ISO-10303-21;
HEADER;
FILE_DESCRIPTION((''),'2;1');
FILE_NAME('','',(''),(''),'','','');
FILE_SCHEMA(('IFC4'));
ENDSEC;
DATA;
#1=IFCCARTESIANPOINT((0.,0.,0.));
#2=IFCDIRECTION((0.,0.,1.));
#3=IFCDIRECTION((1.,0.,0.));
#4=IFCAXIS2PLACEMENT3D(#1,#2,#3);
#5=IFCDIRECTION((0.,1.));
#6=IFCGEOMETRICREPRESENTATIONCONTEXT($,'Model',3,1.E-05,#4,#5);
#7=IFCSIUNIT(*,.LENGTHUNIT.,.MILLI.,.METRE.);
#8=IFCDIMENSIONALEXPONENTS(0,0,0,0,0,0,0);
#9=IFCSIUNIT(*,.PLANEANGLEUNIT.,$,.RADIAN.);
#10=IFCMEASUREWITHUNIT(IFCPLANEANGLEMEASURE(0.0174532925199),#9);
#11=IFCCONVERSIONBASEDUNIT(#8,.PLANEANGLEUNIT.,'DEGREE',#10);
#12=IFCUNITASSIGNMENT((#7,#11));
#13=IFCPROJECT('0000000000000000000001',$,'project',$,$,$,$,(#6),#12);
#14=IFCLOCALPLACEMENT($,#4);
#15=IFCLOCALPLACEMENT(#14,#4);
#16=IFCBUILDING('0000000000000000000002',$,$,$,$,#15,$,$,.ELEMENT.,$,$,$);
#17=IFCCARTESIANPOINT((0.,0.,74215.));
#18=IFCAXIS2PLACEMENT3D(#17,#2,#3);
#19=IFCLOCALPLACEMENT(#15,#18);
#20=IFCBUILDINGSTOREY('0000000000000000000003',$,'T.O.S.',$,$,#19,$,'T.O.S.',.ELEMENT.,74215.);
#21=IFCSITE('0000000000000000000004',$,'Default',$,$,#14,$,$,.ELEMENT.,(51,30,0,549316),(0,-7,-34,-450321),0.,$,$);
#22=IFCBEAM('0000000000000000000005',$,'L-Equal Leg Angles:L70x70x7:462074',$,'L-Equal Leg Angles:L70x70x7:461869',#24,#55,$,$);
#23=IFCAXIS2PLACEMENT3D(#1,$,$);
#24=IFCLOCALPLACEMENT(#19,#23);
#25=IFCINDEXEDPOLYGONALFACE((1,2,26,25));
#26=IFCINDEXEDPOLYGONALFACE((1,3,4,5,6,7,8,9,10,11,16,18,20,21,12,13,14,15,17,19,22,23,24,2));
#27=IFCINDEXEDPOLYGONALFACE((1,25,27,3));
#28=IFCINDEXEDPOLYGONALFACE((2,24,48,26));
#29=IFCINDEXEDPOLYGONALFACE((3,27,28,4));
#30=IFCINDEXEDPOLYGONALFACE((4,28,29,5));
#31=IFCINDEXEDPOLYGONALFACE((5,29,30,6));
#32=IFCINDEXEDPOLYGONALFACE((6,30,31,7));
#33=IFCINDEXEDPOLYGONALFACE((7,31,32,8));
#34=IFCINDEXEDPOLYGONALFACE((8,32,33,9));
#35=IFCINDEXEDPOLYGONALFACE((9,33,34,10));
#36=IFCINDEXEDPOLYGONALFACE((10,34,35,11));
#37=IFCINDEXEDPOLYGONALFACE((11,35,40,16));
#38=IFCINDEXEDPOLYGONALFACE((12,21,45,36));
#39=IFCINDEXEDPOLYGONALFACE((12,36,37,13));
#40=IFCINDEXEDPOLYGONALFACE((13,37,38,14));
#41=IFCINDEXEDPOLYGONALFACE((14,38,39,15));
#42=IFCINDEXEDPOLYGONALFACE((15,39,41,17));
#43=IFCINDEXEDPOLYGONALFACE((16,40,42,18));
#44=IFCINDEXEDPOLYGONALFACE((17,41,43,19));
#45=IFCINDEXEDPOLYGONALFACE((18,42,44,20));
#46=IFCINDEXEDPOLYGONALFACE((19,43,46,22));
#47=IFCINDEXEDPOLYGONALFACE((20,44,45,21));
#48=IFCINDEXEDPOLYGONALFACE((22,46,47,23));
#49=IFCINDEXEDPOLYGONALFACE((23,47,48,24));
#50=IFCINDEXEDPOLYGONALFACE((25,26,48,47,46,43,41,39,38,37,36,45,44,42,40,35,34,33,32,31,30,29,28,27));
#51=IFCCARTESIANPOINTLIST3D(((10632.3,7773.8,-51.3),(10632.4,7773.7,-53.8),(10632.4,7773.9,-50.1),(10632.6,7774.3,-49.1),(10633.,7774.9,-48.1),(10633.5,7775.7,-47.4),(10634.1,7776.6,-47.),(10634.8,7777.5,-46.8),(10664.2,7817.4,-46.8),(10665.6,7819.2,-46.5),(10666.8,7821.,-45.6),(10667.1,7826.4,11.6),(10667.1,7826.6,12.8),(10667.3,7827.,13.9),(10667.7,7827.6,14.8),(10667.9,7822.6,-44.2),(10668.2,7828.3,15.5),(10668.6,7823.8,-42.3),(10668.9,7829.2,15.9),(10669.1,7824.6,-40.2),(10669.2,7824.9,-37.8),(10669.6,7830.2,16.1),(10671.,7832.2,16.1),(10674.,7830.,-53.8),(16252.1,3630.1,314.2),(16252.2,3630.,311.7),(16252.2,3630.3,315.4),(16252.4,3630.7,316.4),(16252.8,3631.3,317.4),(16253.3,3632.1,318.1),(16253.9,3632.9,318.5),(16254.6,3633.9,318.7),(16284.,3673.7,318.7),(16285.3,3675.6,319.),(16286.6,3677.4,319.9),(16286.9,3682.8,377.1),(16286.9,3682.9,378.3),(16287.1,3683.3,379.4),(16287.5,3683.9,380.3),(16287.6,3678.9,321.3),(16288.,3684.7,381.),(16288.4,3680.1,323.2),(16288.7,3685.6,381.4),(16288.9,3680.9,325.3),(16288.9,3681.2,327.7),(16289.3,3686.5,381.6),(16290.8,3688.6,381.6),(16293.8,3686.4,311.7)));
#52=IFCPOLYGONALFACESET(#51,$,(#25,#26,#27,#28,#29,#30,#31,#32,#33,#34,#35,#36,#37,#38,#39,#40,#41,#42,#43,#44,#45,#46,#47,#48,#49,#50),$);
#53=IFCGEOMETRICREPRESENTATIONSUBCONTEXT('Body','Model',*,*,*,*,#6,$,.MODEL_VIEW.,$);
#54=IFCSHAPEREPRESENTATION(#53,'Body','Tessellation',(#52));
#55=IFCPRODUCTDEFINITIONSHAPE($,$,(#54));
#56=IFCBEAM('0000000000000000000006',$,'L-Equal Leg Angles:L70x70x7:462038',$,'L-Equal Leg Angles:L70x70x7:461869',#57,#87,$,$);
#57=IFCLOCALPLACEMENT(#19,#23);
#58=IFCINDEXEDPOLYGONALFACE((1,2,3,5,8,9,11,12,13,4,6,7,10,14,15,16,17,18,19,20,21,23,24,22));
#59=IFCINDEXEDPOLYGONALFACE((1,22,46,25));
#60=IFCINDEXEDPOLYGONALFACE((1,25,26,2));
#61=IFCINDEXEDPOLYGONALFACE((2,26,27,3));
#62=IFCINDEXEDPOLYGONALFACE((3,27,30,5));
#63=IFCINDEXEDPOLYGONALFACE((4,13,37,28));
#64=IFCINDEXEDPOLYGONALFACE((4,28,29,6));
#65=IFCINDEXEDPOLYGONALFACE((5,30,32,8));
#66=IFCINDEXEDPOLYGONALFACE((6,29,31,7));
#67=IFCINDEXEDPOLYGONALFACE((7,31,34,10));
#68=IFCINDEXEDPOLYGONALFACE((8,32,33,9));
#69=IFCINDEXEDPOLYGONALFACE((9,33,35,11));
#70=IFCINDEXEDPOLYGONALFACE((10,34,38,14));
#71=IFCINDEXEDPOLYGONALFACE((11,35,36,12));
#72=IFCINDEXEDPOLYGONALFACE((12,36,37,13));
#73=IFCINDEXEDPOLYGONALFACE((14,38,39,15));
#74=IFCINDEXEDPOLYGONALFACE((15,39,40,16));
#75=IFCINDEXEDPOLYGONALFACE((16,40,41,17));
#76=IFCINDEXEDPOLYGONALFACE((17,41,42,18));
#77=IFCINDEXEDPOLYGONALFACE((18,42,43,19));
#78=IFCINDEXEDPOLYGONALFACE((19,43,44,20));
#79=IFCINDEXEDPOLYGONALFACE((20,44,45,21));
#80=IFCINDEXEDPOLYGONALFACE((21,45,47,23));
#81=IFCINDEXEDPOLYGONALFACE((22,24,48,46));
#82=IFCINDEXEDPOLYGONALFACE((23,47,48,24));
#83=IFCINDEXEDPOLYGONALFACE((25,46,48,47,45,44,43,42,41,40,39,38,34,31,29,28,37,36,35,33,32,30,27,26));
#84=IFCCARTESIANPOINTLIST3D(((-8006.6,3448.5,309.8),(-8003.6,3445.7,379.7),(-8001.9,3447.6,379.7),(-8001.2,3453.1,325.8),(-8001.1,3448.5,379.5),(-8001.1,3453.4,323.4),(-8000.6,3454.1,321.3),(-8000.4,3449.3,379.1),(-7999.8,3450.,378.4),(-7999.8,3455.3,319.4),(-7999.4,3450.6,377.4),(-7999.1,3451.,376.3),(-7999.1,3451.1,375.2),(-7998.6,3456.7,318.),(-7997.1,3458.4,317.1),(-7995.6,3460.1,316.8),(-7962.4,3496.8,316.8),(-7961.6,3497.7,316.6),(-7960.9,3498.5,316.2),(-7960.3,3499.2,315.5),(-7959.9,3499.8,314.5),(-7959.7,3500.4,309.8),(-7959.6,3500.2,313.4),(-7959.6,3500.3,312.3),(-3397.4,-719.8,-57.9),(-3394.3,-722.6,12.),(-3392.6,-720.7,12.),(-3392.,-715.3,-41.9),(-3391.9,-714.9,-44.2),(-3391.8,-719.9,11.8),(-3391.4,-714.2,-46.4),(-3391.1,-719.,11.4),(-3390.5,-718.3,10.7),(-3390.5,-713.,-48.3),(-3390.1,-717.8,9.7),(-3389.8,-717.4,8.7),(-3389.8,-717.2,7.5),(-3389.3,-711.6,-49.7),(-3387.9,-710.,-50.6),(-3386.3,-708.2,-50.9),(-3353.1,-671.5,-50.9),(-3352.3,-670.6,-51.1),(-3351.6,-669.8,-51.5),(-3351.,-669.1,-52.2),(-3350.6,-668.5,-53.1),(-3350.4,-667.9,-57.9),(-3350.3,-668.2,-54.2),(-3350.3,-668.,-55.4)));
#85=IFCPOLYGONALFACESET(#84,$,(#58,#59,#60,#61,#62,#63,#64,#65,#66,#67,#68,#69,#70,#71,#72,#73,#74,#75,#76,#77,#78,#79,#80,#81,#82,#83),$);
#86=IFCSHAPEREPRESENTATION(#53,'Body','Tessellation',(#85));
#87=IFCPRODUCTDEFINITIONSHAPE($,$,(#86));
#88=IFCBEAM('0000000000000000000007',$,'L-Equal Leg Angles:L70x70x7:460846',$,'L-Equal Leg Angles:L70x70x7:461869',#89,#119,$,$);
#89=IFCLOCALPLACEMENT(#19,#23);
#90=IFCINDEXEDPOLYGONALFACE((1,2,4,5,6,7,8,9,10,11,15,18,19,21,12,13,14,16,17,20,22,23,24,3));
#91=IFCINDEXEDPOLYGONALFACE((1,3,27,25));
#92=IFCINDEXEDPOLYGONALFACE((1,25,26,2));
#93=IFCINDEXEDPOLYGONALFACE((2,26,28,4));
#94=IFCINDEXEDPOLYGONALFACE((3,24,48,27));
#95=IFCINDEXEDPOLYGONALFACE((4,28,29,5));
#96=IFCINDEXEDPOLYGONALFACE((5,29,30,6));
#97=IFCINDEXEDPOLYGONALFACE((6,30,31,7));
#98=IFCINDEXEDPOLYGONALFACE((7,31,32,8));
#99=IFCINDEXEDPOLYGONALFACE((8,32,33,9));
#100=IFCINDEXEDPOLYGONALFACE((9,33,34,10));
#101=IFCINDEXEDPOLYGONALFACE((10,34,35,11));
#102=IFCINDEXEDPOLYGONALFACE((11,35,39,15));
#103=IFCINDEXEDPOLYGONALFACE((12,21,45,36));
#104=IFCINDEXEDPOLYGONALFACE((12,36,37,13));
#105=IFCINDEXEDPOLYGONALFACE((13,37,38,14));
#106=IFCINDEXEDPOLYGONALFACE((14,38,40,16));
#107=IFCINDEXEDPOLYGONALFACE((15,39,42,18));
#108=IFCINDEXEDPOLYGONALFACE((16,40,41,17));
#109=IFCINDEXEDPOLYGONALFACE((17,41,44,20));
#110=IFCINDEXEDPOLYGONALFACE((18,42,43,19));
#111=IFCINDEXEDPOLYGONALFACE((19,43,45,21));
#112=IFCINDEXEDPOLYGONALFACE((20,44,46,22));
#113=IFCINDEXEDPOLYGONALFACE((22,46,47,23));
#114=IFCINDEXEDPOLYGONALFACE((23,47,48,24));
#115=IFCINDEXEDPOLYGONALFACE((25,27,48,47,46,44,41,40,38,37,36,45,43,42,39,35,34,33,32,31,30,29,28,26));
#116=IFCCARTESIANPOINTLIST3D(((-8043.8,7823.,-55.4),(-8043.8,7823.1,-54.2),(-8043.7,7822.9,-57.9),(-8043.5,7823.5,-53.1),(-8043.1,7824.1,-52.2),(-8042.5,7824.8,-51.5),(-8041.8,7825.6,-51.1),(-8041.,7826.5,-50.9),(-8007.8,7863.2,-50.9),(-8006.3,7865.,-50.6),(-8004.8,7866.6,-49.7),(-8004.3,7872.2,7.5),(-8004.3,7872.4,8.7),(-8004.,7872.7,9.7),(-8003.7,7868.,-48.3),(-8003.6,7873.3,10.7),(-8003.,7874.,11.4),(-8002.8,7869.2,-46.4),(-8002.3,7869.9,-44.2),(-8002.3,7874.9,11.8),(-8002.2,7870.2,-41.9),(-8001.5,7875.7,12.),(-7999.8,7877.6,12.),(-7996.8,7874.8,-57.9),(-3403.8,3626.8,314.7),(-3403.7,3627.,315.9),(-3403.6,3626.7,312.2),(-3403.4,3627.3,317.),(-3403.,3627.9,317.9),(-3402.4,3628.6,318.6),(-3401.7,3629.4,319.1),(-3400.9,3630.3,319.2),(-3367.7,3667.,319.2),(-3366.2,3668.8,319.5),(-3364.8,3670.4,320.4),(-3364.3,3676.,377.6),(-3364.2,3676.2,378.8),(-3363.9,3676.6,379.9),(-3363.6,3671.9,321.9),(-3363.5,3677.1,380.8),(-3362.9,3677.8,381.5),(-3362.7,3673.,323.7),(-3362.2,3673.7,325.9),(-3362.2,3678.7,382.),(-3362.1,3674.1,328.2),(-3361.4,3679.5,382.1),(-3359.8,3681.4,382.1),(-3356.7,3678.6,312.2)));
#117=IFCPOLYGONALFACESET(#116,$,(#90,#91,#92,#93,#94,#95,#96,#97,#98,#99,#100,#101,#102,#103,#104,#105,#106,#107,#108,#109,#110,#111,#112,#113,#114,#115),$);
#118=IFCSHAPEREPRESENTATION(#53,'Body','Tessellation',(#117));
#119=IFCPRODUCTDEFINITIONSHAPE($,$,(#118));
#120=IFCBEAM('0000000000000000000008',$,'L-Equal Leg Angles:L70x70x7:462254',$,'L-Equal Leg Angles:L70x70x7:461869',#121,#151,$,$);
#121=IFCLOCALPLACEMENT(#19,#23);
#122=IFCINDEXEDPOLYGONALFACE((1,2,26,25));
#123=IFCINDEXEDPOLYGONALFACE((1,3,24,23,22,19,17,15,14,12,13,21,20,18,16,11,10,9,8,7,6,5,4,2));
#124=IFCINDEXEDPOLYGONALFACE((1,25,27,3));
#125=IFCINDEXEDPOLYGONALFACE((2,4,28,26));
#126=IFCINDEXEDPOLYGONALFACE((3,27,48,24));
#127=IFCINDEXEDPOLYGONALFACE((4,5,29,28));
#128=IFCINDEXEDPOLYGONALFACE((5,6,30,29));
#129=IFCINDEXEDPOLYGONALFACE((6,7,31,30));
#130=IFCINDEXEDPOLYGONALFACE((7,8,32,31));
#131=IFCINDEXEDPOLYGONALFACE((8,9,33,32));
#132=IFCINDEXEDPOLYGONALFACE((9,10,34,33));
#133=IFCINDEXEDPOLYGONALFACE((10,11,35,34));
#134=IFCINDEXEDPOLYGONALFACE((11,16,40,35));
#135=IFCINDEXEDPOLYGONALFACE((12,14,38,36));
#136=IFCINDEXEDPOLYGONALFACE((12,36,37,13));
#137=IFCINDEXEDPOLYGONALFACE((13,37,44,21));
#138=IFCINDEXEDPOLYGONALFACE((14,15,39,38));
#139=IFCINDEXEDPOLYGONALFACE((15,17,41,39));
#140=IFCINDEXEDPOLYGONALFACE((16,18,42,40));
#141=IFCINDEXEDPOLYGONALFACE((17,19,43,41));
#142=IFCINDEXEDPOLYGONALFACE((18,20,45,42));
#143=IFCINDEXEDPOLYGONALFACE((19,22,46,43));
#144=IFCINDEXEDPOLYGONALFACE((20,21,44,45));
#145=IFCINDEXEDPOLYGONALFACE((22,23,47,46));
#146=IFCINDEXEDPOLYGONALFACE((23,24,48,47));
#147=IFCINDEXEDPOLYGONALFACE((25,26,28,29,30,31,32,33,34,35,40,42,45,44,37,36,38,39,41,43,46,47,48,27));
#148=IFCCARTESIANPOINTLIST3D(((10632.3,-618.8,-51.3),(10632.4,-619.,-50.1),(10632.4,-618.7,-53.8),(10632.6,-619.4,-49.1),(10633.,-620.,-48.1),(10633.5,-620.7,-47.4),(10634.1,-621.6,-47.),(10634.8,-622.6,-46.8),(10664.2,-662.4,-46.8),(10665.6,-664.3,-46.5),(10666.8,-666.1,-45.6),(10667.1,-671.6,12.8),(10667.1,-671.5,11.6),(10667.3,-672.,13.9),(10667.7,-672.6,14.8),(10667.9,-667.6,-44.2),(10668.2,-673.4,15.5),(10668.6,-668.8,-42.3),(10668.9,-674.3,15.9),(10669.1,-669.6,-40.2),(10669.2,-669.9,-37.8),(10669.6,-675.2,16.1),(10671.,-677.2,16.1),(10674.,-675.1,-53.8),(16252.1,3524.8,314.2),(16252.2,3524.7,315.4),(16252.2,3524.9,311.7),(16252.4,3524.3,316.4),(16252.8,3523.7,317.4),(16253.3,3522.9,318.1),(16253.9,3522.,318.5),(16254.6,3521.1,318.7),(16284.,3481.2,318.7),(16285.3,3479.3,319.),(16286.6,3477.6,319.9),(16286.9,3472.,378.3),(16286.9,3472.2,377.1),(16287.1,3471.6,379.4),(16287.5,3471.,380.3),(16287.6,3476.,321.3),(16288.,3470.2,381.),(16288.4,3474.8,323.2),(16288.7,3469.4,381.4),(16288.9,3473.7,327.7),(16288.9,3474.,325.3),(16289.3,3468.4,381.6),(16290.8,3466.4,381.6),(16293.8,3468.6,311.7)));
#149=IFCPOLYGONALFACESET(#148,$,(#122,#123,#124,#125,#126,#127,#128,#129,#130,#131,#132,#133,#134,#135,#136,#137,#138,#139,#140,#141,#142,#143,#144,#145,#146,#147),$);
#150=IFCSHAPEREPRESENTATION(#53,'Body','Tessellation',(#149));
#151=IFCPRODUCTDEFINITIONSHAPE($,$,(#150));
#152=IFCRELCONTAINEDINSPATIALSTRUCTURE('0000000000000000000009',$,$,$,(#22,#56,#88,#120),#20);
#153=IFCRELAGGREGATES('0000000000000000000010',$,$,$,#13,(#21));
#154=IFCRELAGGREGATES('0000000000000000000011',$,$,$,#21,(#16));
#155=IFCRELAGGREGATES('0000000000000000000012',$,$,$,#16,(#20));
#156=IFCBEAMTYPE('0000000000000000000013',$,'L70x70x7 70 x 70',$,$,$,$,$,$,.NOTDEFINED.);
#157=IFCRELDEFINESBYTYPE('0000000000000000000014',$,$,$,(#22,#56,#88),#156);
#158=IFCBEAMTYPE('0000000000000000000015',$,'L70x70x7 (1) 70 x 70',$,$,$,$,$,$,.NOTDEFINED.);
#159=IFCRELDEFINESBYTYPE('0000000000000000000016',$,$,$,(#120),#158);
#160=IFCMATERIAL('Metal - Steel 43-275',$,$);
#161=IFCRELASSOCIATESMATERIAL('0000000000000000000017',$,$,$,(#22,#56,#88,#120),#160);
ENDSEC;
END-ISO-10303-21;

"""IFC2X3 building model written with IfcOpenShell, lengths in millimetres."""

from ifc_helpers import new_model, entity, si_unit, converted_unit, point, direction, frame, frame_2d, origin_with_axes, place, context, subcontext, project, spatial, polyline, circle_curve, parameter, trimmed, segment, composite_curve, outline, extrude, clip, halfspace, material, type_object, element, save


model = new_model("IFC2X3")

# Units and contexts
model_context = context("Model", 3, precision=1e-05, world=origin_with_axes(), true_north=direction((0.0, 1.0)))
body_context = subcontext(model_context, "Body", "Model", "MODEL_VIEW")
ifc_project = project(units=[si_unit("LENGTHUNIT", "METRE", prefix="MILLI"), converted_unit("PLANEANGLEUNIT", "DEGREE", entity("IfcPlaneAngleMeasure", 0.0174532925199), si_unit("PLANEANGLEUNIT", "RADIAN"), dimensions=[0, 0, 0, 0, 0, 0, 0])], contexts=[model_context])

# Site, building, storey
site_placement = place(None, origin_with_axes())
site = spatial("IfcSite", under=ifc_project, at=site_placement, Name="Default", CompositionType="ELEMENT", RefLatitude=(51, 30, 0, 549316), RefLongitude=(0, -7, -34, -450321), RefElevation=0.0)
building_placement = place(site_placement, origin_with_axes())
building = spatial("IfcBuilding", under=site, at=building_placement, CompositionType="ELEMENT")
storey_placement = place(building_placement, frame((0.0, 0.0, 74215.0), z_axis=(0.0, 0.0, 1.0), x_axis=(1.0, 0.0, 0.0)))
storey = spatial("IfcBuildingStorey", under=building, at=storey_placement, Name="T.O.S.", LongName="T.O.S.", CompositionType="ELEMENT", Elevation=74215.0)

# Beams
ifc_material = material(Name="Metal - Steel 43-275")
beam_type_1 = type_object("IfcBeamType", Name="L70x70x7 70 x 70", PredefinedType="NOTDEFINED")
beam_1_placement = place(storey_placement, frame((16281.1, 3662.9, 338.4), z_axis=(0.0, 0.0, 1.0), x_axis=(0.593453, 0.804869, 0.0)))
element("IfcBeam", 1, at=beam_1_placement, inside=storey, type_object=beam_type_1, material=ifc_material, Name="L-Equal Leg Angles:L70x70x7:462074", ObjectType="L-Equal Leg Angles:L70x70x7:461869", context=body_context, shape_type="Clipping", body=[
    clip(clip(clip(clip(extrude(outline(composite_curve([segment(polyline([(23.9, -43.6), (26.4, -43.6), (26.4, 26.4), (-43.6, 26.4), (-43.6, 23.9)]), True, "CONTINUOUS"), segment(trimmed(circle_curve(frame_2d((-39.1, 23.9), x_axis=(-1.0, 0.0)), 4.5), [point((-43.6, 23.9)), parameter(0.0)], [point((-39.1, 19.4)), parameter(90.0)], True, "CARTESIAN"), True, "CONTINUOUS"), segment(polyline([(-39.1, 19.4), (10.4, 19.4)]), True, "CONTINUOUS"), segment(trimmed(circle_curve(frame_2d((10.4, 10.4), x_axis=(1.0, 0.0)), 9.0), [point((10.4, 19.4)), parameter(90.0)], [point((19.4, 10.4)), parameter(0.0)], False, "CARTESIAN"), True, "CONTINUOUS"), segment(polyline([(19.4, 10.4), (19.4, -39.1)]), True, "CONTINUOUS"), segment(trimmed(circle_curve(frame_2d((23.9, -39.1), x_axis=(-1.0, 0.0)), 4.5), [point((19.4, -39.1)), parameter(0.0)], [point((23.9, -43.6)), parameter(90.0)], True, "CARTESIAN"), True, "CONTINUOUS")], self_intersect=False)), frame((0.0, 6997.8, -366.3), z_axis=(0.0, -0.998633, 0.052275), x_axis=(0.0, -0.052275, -0.998633)), (0.0, 0.0, 1.0), 7012.5), halfspace(frame((0.0, 6987.4, -365.8), z_axis=(0.0, -0.998633, 0.052275), x_axis=(0.0, -0.052275, -0.998633)), True)), halfspace(frame((0.0, 5.2, -0.3), z_axis=(0.0, 0.998633, -0.052275), x_axis=(0.0, 0.052275, 0.998633)), True)), halfspace(frame((0.0, 6992.6, 0.0), z_axis=(0.0, -1.0, 0.0), x_axis=(0.0, 0.0, -1.0)), True)), halfspace(frame((0.0, 0.0, 0.0), z_axis=(0.0, 1.0, 0.0), x_axis=(0.0, 0.0, 1.0)), True)),
])
beam_2_placement = place(storey_placement, frame((-7992.1, 3471.0, 336.5), z_axis=(0.0, 0.0, 1.0), x_axis=(-0.670739, -0.741693, 0.0)))
element("IfcBeam", 2, at=beam_2_placement, inside=storey, type_object=beam_type_1, material=ifc_material, Name="L-Equal Leg Angles:L70x70x7:462038", ObjectType="L-Equal Leg Angles:L70x70x7:461869", context=body_context, shape_type="Clipping", body=[
    clip(clip(clip(clip(extrude(outline(composite_curve([segment(polyline([(23.9, -43.6), (26.4, -43.6), (26.4, 26.4), (-43.6, 26.4), (-43.6, 23.9)]), True, "CONTINUOUS"), segment(trimmed(circle_curve(frame_2d((-39.1, 23.9), x_axis=(-1.0, 0.0)), 4.5), [point((-43.6, 23.9)), parameter(0.0)], [point((-39.1, 19.4)), parameter(90.0)], True, "CARTESIAN"), True, "CONTINUOUS"), segment(polyline([(-39.1, 19.4), (10.4, 19.4)]), True, "CONTINUOUS"), segment(trimmed(circle_curve(frame_2d((10.4, 10.4), x_axis=(1.0, 0.0)), 9.0), [point((10.4, 19.4)), parameter(90.0)], [point((19.4, 10.4)), parameter(0.0)], False, "CARTESIAN"), True, "CONTINUOUS"), segment(polyline([(19.4, 10.4), (19.4, -39.1)]), True, "CONTINUOUS"), segment(trimmed(circle_curve(frame_2d((23.9, -39.1), x_axis=(-1.0, 0.0)), 4.5), [point((19.4, -39.1)), parameter(0.0)], [point((23.9, -43.6)), parameter(90.0)], True, "CARTESIAN"), True, "CONTINUOUS")], self_intersect=False)), frame((0.0, 6232.1, -368.7), z_axis=(0.0, -0.998254, 0.059061), x_axis=(0.0, -0.059061, -0.998254)), (0.0, 0.0, 1.0), 6248.8), halfspace(frame((0.0, 6220.4, -368.0), z_axis=(0.0, -0.998254, 0.059061), x_axis=(0.0, -0.059061, -0.998254)), True)), halfspace(frame((0.0, 5.8, -0.3), z_axis=(0.0, 0.998254, -0.059061), x_axis=(0.0, 0.059061, 0.998254)), True)), halfspace(frame((0.0, 6226.2, 0.0), z_axis=(0.0, -1.0, 0.0), x_axis=(0.0, 0.0, -1.0)), True)), halfspace(frame((0.0, 0.0, 0.0), z_axis=(0.0, 1.0, 0.0), x_axis=(0.0, 0.0, 1.0)), True)),
])
beam_3_placement = place(storey_placement, frame((-3371.3, 3656.1, 339.0), z_axis=(0.0, 0.0, 1.0), x_axis=(0.670739, 0.741693, 0.0)))
element("IfcBeam", 3, at=beam_3_placement, inside=storey, type_object=beam_type_1, material=ifc_material, Name="L-Equal Leg Angles:L70x70x7:460846", ObjectType="L-Equal Leg Angles:L70x70x7:461869", context=body_context, shape_type="Clipping", body=[
    clip(clip(clip(clip(extrude(outline(composite_curve([segment(polyline([(23.9, -43.6), (26.4, -43.6), (26.4, 26.4), (-43.6, 26.4), (-43.6, 23.9)]), True, "CONTINUOUS"), segment(trimmed(circle_curve(frame_2d((-39.1, 23.9), x_axis=(-1.0, 0.0)), 4.5), [point((-43.6, 23.9)), parameter(0.0)], [point((-39.1, 19.4)), parameter(90.0)], True, "CARTESIAN"), True, "CONTINUOUS"), segment(polyline([(-39.1, 19.4), (10.4, 19.4)]), True, "CONTINUOUS"), segment(trimmed(circle_curve(frame_2d((10.4, 10.4), x_axis=(1.0, 0.0)), 9.0), [point((10.4, 19.4)), parameter(90.0)], [point((19.4, 10.4)), parameter(0.0)], False, "CARTESIAN"), True, "CONTINUOUS"), segment(polyline([(19.4, 10.4), (19.4, -39.1)]), True, "CONTINUOUS"), segment(trimmed(circle_curve(frame_2d((23.9, -39.1), x_axis=(-1.0, 0.0)), 4.5), [point((19.4, -39.1)), parameter(0.0)], [point((23.9, -43.6)), parameter(90.0)], True, "CARTESIAN"), True, "CONTINUOUS")], self_intersect=False)), frame((0.0, 6273.6, -371.2), z_axis=(0.0, -0.998254, 0.059061), x_axis=(0.0, -0.059061, -0.998254)), (0.0, 0.0, 1.0), 6290.4), halfspace(frame((0.0, 6261.9, -370.5), z_axis=(0.0, -0.998254, 0.059061), x_axis=(0.0, -0.059061, -0.998254)), True)), halfspace(frame((0.0, 5.8, -0.3), z_axis=(0.0, 0.998254, -0.059061), x_axis=(0.0, 0.059061, 0.998254)), True)), halfspace(frame((0.0, 6267.8, 0.0), z_axis=(0.0, -1.0, 0.0), x_axis=(0.0, 0.0, -1.0)), True)), halfspace(frame((0.0, 0.0, 0.0), z_axis=(0.0, 1.0, 0.0), x_axis=(0.0, 0.0, 1.0)), True)),
])
beam_type_2 = type_object("IfcBeamType", Name="L70x70x7 (1) 70 x 70", PredefinedType="NOTDEFINED")
beam_4_placement = place(storey_placement, frame((16281.1, 3492.1, 338.4), z_axis=(0.0, 0.0, 1.0), x_axis=(-0.593453, 0.804869, 0.0)))
element("IfcBeam", 4, at=beam_4_placement, inside=storey, type_object=beam_type_2, material=ifc_material, Name="L-Equal Leg Angles:L70x70x7:462254", ObjectType="L-Equal Leg Angles:L70x70x7:461869", context=body_context, shape_type="Clipping", body=[
    clip(clip(clip(clip(extrude(outline(composite_curve([segment(polyline([(-43.6, -26.4), (26.4, -26.4), (26.4, 43.6), (23.9, 43.6)]), True, "CONTINUOUS"), segment(trimmed(circle_curve(frame_2d((23.9, 39.1), x_axis=(0.0, 1.0)), 4.5), [point((23.9, 43.6)), parameter(0.0)], [point((19.4, 39.1)), parameter(90.0)], True, "CARTESIAN"), True, "CONTINUOUS"), segment(polyline([(19.4, 39.1), (19.4, -10.4)]), True, "CONTINUOUS"), segment(trimmed(circle_curve(frame_2d((10.4, -10.4), x_axis=(0.0, -1.0)), 9.0), [point((19.4, -10.4)), parameter(90.0)], [point((10.4, -19.4)), parameter(0.0)], False, "CARTESIAN"), True, "CONTINUOUS"), segment(polyline([(10.4, -19.4), (-39.1, -19.4)]), True, "CONTINUOUS"), segment(trimmed(circle_curve(frame_2d((-39.1, -23.9), x_axis=(0.0, 1.0)), 4.5), [point((-39.1, -19.4)), parameter(0.0)], [point((-43.6, -23.9)), parameter(90.0)], True, "CARTESIAN"), True, "CONTINUOUS"), segment(polyline([(-43.6, -23.9), (-43.6, -26.4)]), True, "CONTINUOUS")], self_intersect=False)), frame((0.0, 6997.8, -366.3), z_axis=(0.0, -0.998633, 0.052275), x_axis=(0.0, -0.052275, -0.998633)), (0.0, 0.0, 1.0), 7012.5), halfspace(frame((0.0, 6987.4, -365.8), z_axis=(0.0, -0.998633, 0.052275), x_axis=(0.0, -0.052275, -0.998633)), True)), halfspace(frame((0.0, 5.2, -0.3), z_axis=(0.0, 0.998633, -0.052275), x_axis=(0.0, 0.052275, 0.998633)), True)), halfspace(frame((0.0, 6992.6, 0.0), z_axis=(0.0, -1.0, 0.0), x_axis=(0.0, 0.0, -1.0)), True)), halfspace(frame((0.0, 0.0, 0.0), z_axis=(0.0, 1.0, 0.0), x_axis=(0.0, 0.0, 1.0)), True)),
])

save(model, "model.ifc")
